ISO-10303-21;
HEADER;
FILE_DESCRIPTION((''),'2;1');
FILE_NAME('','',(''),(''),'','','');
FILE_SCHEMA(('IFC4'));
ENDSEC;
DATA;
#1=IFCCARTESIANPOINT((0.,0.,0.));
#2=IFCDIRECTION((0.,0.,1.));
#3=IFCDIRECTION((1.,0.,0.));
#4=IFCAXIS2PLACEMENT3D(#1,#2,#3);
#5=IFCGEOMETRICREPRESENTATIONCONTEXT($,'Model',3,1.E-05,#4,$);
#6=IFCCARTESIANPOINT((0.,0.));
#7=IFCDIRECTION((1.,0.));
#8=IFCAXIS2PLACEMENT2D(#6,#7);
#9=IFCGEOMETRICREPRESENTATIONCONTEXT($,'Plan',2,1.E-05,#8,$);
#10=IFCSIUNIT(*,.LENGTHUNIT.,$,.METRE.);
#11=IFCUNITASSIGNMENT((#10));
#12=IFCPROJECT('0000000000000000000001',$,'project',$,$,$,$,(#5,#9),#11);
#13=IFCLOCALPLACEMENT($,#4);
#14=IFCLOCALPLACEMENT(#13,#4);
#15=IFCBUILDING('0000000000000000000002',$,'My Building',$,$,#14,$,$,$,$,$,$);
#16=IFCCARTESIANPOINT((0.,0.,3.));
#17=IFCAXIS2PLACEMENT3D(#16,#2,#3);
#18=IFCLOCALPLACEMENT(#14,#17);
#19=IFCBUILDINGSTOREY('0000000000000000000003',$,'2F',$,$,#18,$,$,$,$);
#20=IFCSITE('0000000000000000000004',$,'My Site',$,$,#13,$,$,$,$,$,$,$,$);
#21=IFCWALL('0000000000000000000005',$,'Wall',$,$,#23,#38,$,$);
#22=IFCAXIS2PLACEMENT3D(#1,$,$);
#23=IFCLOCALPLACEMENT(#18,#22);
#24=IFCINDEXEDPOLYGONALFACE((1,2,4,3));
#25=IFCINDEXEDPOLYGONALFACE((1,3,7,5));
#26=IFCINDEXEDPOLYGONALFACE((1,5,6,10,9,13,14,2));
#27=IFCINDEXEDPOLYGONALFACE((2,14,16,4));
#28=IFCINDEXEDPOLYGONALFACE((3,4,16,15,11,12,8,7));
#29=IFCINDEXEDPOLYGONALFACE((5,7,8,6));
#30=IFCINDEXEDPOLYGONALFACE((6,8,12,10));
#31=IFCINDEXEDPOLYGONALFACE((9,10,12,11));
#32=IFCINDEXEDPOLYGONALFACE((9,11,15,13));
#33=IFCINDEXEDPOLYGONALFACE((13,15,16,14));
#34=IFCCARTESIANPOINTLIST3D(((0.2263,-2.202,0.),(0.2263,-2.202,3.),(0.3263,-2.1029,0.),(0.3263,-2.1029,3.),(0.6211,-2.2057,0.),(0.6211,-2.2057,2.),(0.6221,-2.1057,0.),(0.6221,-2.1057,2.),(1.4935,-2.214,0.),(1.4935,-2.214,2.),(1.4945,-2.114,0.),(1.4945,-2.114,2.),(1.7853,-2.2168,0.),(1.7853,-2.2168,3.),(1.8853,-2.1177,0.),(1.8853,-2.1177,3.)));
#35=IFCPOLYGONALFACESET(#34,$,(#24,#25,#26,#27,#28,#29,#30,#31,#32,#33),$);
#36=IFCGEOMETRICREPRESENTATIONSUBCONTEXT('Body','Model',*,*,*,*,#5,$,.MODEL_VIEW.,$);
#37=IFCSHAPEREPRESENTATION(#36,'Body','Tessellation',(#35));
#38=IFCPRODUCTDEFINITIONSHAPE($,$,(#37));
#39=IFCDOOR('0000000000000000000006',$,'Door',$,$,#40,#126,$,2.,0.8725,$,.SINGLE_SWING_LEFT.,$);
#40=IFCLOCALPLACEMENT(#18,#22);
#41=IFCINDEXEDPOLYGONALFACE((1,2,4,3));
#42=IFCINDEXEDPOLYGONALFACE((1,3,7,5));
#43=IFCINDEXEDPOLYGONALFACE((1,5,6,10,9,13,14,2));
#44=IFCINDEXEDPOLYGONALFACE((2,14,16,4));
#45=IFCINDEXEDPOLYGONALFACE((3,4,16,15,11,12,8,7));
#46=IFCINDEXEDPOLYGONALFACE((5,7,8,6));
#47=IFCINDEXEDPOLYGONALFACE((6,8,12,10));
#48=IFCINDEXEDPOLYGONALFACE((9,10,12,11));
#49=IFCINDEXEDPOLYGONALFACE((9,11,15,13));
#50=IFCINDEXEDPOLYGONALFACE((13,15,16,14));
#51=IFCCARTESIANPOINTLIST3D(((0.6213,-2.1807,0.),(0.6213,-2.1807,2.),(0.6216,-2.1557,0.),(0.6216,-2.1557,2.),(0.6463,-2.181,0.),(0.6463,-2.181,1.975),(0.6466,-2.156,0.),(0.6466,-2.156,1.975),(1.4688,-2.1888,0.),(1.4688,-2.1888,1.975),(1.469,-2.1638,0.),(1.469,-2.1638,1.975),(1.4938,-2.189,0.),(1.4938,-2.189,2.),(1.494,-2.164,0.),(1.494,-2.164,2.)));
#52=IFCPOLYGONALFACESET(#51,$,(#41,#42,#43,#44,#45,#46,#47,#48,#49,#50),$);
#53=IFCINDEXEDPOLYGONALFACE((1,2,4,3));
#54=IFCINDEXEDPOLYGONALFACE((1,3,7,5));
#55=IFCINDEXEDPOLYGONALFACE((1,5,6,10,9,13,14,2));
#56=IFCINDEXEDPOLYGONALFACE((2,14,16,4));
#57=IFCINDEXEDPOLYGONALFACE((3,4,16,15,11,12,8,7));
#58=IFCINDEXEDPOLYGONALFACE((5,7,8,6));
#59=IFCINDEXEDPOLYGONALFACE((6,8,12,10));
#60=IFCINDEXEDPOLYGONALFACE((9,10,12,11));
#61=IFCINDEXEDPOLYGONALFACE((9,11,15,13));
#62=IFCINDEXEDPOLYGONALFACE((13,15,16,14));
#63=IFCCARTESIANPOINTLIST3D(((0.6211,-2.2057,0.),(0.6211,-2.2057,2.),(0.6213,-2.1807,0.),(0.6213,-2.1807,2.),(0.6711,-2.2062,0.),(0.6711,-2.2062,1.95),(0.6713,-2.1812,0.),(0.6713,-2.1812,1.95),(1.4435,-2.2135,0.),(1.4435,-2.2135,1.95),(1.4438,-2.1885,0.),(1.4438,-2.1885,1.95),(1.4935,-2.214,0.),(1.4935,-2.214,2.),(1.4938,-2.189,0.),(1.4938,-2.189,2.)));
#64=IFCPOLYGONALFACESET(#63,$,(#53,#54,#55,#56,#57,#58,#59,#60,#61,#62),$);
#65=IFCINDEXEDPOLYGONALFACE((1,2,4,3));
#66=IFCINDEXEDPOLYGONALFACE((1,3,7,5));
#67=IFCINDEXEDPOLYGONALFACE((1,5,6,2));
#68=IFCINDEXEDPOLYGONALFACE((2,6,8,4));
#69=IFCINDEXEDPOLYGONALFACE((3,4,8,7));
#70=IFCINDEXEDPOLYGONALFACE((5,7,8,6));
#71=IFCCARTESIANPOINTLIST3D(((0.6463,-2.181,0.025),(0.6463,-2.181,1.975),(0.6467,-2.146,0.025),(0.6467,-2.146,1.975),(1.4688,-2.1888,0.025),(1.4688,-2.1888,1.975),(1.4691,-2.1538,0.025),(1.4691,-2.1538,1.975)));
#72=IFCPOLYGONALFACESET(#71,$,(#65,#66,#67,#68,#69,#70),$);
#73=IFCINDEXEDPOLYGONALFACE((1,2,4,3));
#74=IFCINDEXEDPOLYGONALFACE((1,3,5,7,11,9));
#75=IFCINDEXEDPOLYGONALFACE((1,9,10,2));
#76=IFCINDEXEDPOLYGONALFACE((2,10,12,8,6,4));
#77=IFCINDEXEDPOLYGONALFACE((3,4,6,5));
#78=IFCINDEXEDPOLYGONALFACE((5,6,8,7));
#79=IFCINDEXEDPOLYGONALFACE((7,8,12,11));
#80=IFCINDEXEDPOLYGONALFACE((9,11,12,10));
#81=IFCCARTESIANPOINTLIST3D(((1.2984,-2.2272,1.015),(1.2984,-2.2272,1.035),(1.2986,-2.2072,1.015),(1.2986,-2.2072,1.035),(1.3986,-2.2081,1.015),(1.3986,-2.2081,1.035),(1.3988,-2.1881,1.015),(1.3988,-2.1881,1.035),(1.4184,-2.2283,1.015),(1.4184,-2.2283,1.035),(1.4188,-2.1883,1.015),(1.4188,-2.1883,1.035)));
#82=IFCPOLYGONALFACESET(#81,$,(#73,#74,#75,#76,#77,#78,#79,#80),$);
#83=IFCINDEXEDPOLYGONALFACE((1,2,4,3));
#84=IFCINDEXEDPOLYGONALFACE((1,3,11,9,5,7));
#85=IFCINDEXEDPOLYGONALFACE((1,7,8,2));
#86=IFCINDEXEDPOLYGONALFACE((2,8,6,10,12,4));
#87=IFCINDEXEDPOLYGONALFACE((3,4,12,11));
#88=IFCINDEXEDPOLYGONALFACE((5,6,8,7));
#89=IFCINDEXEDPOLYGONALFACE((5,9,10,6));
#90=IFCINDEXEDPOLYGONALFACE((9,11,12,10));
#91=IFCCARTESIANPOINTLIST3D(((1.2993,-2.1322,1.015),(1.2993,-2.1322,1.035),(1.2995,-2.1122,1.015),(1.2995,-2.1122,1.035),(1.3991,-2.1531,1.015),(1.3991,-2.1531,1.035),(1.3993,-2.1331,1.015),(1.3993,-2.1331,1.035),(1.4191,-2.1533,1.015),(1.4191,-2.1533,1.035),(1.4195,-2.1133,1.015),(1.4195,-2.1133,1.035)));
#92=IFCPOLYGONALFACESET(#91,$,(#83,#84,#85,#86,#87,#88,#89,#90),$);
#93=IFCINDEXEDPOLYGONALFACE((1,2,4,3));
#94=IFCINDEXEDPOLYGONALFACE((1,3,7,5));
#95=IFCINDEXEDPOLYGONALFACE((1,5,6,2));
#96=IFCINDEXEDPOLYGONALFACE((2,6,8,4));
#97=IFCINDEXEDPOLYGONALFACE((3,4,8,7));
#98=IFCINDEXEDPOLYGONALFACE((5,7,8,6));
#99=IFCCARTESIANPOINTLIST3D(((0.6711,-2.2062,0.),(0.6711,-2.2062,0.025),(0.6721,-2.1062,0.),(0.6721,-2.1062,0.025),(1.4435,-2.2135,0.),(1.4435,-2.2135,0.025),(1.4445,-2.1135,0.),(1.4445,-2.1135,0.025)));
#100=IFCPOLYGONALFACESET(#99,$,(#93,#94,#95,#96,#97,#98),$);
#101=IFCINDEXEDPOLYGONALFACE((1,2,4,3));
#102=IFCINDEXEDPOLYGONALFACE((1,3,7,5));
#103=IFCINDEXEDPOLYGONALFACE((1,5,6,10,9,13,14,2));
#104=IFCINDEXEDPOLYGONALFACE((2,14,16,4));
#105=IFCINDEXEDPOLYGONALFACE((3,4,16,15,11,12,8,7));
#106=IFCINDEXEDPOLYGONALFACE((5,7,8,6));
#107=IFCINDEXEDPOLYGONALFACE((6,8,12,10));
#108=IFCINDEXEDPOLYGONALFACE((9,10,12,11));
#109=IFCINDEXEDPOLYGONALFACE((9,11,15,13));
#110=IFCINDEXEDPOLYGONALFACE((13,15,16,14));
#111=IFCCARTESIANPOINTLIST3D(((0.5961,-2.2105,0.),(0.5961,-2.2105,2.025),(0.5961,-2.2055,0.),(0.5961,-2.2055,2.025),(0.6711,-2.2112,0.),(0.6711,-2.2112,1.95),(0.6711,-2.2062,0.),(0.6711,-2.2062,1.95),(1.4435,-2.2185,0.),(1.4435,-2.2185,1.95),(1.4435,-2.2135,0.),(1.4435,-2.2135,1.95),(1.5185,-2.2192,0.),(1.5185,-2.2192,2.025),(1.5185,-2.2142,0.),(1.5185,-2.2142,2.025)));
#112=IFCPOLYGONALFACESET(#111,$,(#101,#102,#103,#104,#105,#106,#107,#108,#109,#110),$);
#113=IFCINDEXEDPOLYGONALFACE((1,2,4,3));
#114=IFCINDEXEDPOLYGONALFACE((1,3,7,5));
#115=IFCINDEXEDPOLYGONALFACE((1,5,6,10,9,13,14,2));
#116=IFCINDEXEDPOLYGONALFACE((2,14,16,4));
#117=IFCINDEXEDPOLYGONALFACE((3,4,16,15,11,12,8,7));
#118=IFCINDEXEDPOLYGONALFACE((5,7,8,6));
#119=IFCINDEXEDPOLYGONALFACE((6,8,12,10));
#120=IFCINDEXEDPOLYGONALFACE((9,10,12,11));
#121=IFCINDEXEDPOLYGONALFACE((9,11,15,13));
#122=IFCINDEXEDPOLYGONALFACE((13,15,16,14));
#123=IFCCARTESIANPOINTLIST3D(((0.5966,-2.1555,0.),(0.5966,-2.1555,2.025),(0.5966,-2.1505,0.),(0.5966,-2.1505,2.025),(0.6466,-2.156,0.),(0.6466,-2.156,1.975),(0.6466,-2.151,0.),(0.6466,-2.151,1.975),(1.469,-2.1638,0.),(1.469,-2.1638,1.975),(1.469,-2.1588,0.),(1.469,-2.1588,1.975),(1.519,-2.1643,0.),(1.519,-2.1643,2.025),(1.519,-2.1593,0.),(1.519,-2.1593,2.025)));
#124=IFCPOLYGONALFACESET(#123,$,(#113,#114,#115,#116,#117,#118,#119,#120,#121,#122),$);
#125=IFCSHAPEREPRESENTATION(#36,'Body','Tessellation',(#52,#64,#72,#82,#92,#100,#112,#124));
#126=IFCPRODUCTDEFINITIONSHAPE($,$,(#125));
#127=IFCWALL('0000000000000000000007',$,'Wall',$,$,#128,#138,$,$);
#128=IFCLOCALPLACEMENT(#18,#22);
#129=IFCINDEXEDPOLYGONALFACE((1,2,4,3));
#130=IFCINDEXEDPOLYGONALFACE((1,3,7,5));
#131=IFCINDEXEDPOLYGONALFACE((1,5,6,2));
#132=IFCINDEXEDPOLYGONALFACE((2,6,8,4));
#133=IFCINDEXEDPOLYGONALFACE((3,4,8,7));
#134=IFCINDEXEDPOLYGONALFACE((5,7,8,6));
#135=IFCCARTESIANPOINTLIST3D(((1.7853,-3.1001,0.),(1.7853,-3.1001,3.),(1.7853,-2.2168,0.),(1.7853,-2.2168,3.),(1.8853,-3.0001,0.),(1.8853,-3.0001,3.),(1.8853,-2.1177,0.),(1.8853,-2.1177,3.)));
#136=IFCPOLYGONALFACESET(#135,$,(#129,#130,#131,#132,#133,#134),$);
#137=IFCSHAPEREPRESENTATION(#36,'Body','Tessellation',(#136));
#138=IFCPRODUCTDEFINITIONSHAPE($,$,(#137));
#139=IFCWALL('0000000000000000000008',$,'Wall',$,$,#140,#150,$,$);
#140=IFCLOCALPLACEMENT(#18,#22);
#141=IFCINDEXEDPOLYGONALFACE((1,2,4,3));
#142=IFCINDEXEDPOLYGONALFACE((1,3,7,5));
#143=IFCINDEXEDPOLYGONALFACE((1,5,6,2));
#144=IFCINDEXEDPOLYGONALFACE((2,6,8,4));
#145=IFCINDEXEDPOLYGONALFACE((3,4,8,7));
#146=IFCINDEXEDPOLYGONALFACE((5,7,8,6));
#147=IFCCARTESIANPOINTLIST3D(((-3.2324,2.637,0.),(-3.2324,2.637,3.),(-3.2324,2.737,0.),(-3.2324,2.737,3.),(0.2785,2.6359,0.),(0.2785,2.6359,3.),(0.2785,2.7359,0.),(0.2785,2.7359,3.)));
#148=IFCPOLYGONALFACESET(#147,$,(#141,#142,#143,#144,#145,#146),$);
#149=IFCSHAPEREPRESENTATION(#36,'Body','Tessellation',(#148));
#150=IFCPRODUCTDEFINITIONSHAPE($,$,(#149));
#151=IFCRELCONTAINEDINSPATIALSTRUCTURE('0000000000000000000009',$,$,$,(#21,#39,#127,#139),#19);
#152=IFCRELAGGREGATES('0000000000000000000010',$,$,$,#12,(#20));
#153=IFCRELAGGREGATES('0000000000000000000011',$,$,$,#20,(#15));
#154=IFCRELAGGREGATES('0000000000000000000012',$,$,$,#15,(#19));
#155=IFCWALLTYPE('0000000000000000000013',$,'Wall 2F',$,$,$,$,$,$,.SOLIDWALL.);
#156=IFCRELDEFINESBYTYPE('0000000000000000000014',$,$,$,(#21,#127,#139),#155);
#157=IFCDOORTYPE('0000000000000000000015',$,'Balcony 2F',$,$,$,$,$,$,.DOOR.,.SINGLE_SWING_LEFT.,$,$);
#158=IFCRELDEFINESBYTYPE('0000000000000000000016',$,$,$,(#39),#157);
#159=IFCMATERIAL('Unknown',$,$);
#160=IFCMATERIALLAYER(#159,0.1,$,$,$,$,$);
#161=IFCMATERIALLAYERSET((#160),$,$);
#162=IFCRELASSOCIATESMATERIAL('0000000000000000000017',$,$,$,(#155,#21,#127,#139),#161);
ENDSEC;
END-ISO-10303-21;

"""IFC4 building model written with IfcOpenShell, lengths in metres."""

from ifc_helpers import new_model, entity, si_unit, frame, origin_with_axes, origin_2d_with_axis, place, context, subcontext, project, spatial, line, indexed_curve, outline, extrude, shape, source, transform, mapped, material, layer, layer_set, layer_usage, type_object, type_shapes, element, fill, save


model = new_model("IFC4")

# Units and contexts
model_context = context("Model", 3, precision=1e-05, world=origin_with_axes())
plan_context = context("Plan", 2, precision=1e-05, world=origin_2d_with_axis())
body_context_1 = subcontext(model_context, "Body", "Model", "MODEL_VIEW")
body_context_2 = subcontext(plan_context, "Body", "Plan", "PLAN_VIEW")
ifc_project = project(units=[si_unit("LENGTHUNIT", "METRE")], contexts=[model_context, plan_context])

# Site, building, storey
site_placement = place(None, origin_with_axes())
site = spatial("IfcSite", under=ifc_project, at=site_placement, Name="My Site")
building_placement = place(site_placement, origin_with_axes())
building = spatial("IfcBuilding", under=site, at=building_placement, Name="My Building")
storey_placement = place(building_placement, frame((0.0, 0.0, 3.0), z_axis=(0.0, 0.0, 1.0), x_axis=(1.0, 0.0, 0.0)))
storey = spatial("IfcBuildingStorey", under=building, at=storey_placement, Name="2F")

# Shared definitions
ifc_material = material(Name="Unknown")

# Shared definitions
ifc_layer_1 = layer(ifc_material, 0.1)
ifc_layer_set_1 = layer_set([ifc_layer_1])
wall_type = type_object("IfcWallType", Name="Wall 2F", PredefinedType="SOLIDWALL", material=ifc_layer_set_1)

# Wall, opening, door
ifc_layer_usage_1 = layer_usage(ifc_layer_set_1, "AXIS2", "POSITIVE", 0.0)
wall_1_placement = place(storey_placement, frame((0.2263, -2.202, 0.0), z_axis=(0.0, 0.0, 1.0), x_axis=(0.999955, -0.009498, 0.0)))
wall_1 = element("IfcWall", 1, at=wall_1_placement, inside=storey, type_object=wall_type, material=ifc_layer_usage_1, Name="Wall", context=body_context_1, shape_type="SweptSolid", body=[
    extrude(outline(indexed_curve([(0.0, 0.0), (0.0991, 0.1), (1.6581, 0.1), (1.559, 0.0)], segments=[line(1, 2, 3, 4, 1)])), origin_with_axes(), (0.0, 0.0, 1.0), 3.0),
])
shared_shape_1 = source(origin_with_axes(), body_context_1, "Body", "SweptSolid", [
    extrude(outline(indexed_curve([(0.0, 0.0), (0.8725, 0.0), (0.8725, 2.0), (0.0, 2.0)], segments=[line(1, 2, 3, 4, 1)])), frame((0.0, -0.6, 0.0), z_axis=(0.0, -1.0, 0.0), x_axis=(1.0, 0.0, 0.0)), (0.0, 0.0, -1.0), 1.2),
])
opening_1_placement = place(wall_1_placement, frame((0.3948, 0.0, 0.0), z_axis=(0.0, 0.0, 1.0), x_axis=(1.0, 0.0, 0.0)))
opening_1 = element("IfcOpeningElement", 2, at=opening_1_placement, cuts=wall_1, PredefinedType="OPENING", context=body_context_1, shape_type="MappedRepresentation", body=[
    mapped(shared_shape_1, transform((0.0, 0.0, 0.0), x_axis=(1.0, 0.0, 0.0), y_axis=(0.0, 1.0, 0.0), z_axis=(0.0, 0.0, 1.0), scale=1.0)),
])
door_type_1 = type_object("IfcDoorType", Name="Balcony 2F", OperationType="SINGLE_SWING_LEFT", PredefinedType="DOOR")
shared_shape_2 = source(origin_with_axes(), body_context_1, "Body", "SweptSolid", [
    extrude(outline(indexed_curve([(0.0, 0.0), (0.0, 2.0), (0.8725, 2.0), (0.8725, 0.0), (0.8475, 0.0), (0.8475, 1.975), (0.025, 1.975), (0.025, 0.0)], segments=[line(1, 2, 3, 4, 5, 6, 7, 8, 1)])), frame((0.0, 0.025, 0.0), z_axis=(0.0, -1.0, 0.0), x_axis=(1.0, 0.0, 0.0)), (0.0, 0.0, -1.0), 0.025),
    extrude(outline(indexed_curve([(0.0, 0.0), (0.0, 2.0), (0.8725, 2.0), (0.8725, 0.0), (0.8225, 0.0), (0.8225, 1.95), (0.05, 1.95), (0.05, 0.0)], segments=[line(1, 2, 3, 4, 5, 6, 7, 8, 1)])), frame((0.0, 0.0, 0.0), z_axis=(0.0, -1.0, 0.0), x_axis=(1.0, 0.0, 0.0)), (0.0, 0.0, -1.0), 0.025),
    extrude(outline(indexed_curve([(0.0, 0.0), (0.8225, 0.0), (0.8225, 0.035), (0.0, 0.035)], segments=[line(1, 2, 3, 4, 1)])), frame((0.025, 0.025, 0.025), z_axis=(0.0, 0.0, 1.0), x_axis=(1.0, 0.0, 0.0)), (0.0, 0.0, 1.0), 1.95),
    extrude(outline(indexed_curve([(0.0, 0.0), (0.0, -0.04), (-0.12, -0.04), (-0.12, -0.02), (-0.02, -0.02), (-0.02, 0.0)], segments=[line(1, 2, 3, 4, 5, 6, 1)])), frame((0.7975, 0.025, 1.015), z_axis=(0.0, 0.0, 1.0), x_axis=(1.0, 0.0, 0.0)), (0.0, 0.0, 1.0), 0.02),
    extrude(outline(indexed_curve([(0.0, 0.0), (0.0, 0.04), (-0.12, 0.04), (-0.12, 0.02), (-0.02, 0.02), (-0.02, 0.0)], segments=[line(1, 2, 3, 4, 5, 6, 1)])), frame((0.7975, 0.06, 1.015), z_axis=(0.0, 0.0, 1.0), x_axis=(1.0, 0.0, 0.0)), (0.0, 0.0, 1.0), 0.02),
    extrude(outline(indexed_curve([(0.0, 0.0), (0.7725, 0.0), (0.7725, 0.1), (0.0, 0.1)], segments=[line(1, 2, 3, 4, 1)])), frame((0.05, 0.0, 0.0), z_axis=(0.0, 0.0, 1.0), x_axis=(1.0, 0.0, 0.0)), (0.0, 0.0, 1.0), 0.025),
    extrude(outline(indexed_curve([(0.0, 0.0), (0.0, 2.025), (0.9225, 2.025), (0.9225, 0.0), (0.8475, 0.0), (0.8475, 1.95), (0.075, 1.95), (0.075, 0.0)], segments=[line(1, 2, 3, 4, 5, 6, 7, 8, 1)])), frame((-0.025, -0.005, 0.0), z_axis=(0.0, -1.0, 0.0), x_axis=(1.0, 0.0, 0.0)), (0.0, 0.0, -1.0), 0.005),
    extrude(outline(indexed_curve([(0.0, 0.0), (0.0, 2.025), (0.9225, 2.025), (0.9225, 0.0), (0.8725, 0.0), (0.8725, 1.975), (0.05, 1.975), (0.05, 0.0)], segments=[line(1, 2, 3, 4, 5, 6, 7, 8, 1)])), frame((-0.025, 0.05, 0.0), z_axis=(0.0, -1.0, 0.0), x_axis=(1.0, 0.0, 0.0)), (0.0, 0.0, -1.0), 0.005),
])
shared_shape_3 = source(origin_with_axes(), body_context_2, "Body", "Curve2D", [
    entity("IfcIndexedPolyCurve", entity("IfcCartesianPointList2D", [[0.0, 0.0], [0.0, 0.05], [0.025, 0.05], [0.025, 0.025], [0.05, 0.025], [0.05, 0.0]]), [entity("IfcLineIndex", [1, 2, 3, 4, 5, 6, 1])]),
    entity("IfcIndexedPolyCurve", entity("IfcCartesianPointList2D", [[0.8725, 0.0], [0.8725, 0.05], [0.8475, 0.05], [0.8475, 0.025], [0.8225, 0.025], [0.8225, 0.0]]), [entity("IfcLineIndex", [1, 2, 3, 4, 5, 6, 1])]),
    entity("IfcTrimmedCurve", entity("IfcEllipse", entity("IfcAxis2Placement2D", entity("IfcCartesianPoint", [0.06, 0.05]), entity("IfcDirection", [1.0, 0.0])), 0.7875, 0.8225), [entity("IfcCartesianPoint", [0.8475, 0.05])], [entity("IfcCartesianPoint", [0.06, 0.8725])], True, "CARTESIAN"),
    entity("IfcIndexedPolyCurve", entity("IfcCartesianPointList2D", [[0.025, 0.05], [0.06, 0.05], [0.06, 0.8725], [0.025, 0.8725]]), [entity("IfcLineIndex", [1, 2, 3, 4, 1])]),
])
type_shapes(door_type_1, [shared_shape_2, shared_shape_3])
door_1_placement = place(opening_1_placement, frame((0.0, 0.0, 0.0), z_axis=(0.0, 0.0, 1.0), x_axis=(1.0, 0.0, 0.0)))
door_1 = element("IfcDoor", 3, at=door_1_placement, inside=storey, type_object=door_type_1, Name="Door", OperationType="SINGLE_SWING_LEFT", OverallHeight=2.0, OverallWidth=0.8725, shapes=[
    shape(body_context_1, "Body", "MappedRepresentation", [mapped(shared_shape_2, transform((0.0, 0.0, 0.0), x_axis=(1.0, 0.0, 0.0), y_axis=(0.0, 1.0, 0.0), z_axis=(0.0, 0.0, 1.0), scale=1.0))]),
    shape(body_context_2, "Body", "MappedRepresentation", [mapped(shared_shape_3, transform((0.0, 0.0, 0.0), x_axis=(1.0, 0.0, 0.0), y_axis=(0.0, 1.0, 0.0), z_axis=(0.0, 0.0, 1.0), scale=1.0))]),
])
fill(opening_1, door_1)

# Walls
ifc_layer_usage_2 = layer_usage(ifc_layer_set_1, "AXIS2", "POSITIVE", 0.0)
wall_2_placement = place(storey_placement, frame((1.7853, -2.2168, 0.0), z_axis=(0.0, 0.0, 1.0), x_axis=(0.0, -1.0, 0.0)))
element("IfcWall", 4, at=wall_2_placement, inside=storey, type_object=wall_type, material=ifc_layer_usage_2, Name="Wall", context=body_context_1, shape_type="SweptSolid", body=[
    extrude(outline(indexed_curve([(0.0, 0.0), (-0.0991, 0.1), (0.7833, 0.1), (0.8833, 0.0)], segments=[line(1, 2, 3, 4, 1)])), origin_with_axes(), (0.0, 0.0, 1.0), 3.0),
])
ifc_layer_usage_3 = layer_usage(ifc_layer_set_1, "AXIS2", "POSITIVE", 0.0)
wall_3_placement = place(storey_placement, frame((-3.2324, 2.637, 0.0), z_axis=(0.0, 0.0, 1.0), x_axis=(1.0, -0.000332, 0.0)))
element("IfcWall", 5, at=wall_3_placement, inside=storey, type_object=wall_type, material=ifc_layer_usage_3, Name="Wall", context=body_context_1, shape_type="SweptSolid", body=[
    extrude(outline(indexed_curve([(0.0, 0.0), (0.0, 0.1), (3.5109, 0.1), (3.5109, 0.0)], segments=[line(1, 2, 3, 4, 1)])), origin_with_axes(), (0.0, 0.0, 1.0), 3.0),
])

save(model, "model.ifc")
